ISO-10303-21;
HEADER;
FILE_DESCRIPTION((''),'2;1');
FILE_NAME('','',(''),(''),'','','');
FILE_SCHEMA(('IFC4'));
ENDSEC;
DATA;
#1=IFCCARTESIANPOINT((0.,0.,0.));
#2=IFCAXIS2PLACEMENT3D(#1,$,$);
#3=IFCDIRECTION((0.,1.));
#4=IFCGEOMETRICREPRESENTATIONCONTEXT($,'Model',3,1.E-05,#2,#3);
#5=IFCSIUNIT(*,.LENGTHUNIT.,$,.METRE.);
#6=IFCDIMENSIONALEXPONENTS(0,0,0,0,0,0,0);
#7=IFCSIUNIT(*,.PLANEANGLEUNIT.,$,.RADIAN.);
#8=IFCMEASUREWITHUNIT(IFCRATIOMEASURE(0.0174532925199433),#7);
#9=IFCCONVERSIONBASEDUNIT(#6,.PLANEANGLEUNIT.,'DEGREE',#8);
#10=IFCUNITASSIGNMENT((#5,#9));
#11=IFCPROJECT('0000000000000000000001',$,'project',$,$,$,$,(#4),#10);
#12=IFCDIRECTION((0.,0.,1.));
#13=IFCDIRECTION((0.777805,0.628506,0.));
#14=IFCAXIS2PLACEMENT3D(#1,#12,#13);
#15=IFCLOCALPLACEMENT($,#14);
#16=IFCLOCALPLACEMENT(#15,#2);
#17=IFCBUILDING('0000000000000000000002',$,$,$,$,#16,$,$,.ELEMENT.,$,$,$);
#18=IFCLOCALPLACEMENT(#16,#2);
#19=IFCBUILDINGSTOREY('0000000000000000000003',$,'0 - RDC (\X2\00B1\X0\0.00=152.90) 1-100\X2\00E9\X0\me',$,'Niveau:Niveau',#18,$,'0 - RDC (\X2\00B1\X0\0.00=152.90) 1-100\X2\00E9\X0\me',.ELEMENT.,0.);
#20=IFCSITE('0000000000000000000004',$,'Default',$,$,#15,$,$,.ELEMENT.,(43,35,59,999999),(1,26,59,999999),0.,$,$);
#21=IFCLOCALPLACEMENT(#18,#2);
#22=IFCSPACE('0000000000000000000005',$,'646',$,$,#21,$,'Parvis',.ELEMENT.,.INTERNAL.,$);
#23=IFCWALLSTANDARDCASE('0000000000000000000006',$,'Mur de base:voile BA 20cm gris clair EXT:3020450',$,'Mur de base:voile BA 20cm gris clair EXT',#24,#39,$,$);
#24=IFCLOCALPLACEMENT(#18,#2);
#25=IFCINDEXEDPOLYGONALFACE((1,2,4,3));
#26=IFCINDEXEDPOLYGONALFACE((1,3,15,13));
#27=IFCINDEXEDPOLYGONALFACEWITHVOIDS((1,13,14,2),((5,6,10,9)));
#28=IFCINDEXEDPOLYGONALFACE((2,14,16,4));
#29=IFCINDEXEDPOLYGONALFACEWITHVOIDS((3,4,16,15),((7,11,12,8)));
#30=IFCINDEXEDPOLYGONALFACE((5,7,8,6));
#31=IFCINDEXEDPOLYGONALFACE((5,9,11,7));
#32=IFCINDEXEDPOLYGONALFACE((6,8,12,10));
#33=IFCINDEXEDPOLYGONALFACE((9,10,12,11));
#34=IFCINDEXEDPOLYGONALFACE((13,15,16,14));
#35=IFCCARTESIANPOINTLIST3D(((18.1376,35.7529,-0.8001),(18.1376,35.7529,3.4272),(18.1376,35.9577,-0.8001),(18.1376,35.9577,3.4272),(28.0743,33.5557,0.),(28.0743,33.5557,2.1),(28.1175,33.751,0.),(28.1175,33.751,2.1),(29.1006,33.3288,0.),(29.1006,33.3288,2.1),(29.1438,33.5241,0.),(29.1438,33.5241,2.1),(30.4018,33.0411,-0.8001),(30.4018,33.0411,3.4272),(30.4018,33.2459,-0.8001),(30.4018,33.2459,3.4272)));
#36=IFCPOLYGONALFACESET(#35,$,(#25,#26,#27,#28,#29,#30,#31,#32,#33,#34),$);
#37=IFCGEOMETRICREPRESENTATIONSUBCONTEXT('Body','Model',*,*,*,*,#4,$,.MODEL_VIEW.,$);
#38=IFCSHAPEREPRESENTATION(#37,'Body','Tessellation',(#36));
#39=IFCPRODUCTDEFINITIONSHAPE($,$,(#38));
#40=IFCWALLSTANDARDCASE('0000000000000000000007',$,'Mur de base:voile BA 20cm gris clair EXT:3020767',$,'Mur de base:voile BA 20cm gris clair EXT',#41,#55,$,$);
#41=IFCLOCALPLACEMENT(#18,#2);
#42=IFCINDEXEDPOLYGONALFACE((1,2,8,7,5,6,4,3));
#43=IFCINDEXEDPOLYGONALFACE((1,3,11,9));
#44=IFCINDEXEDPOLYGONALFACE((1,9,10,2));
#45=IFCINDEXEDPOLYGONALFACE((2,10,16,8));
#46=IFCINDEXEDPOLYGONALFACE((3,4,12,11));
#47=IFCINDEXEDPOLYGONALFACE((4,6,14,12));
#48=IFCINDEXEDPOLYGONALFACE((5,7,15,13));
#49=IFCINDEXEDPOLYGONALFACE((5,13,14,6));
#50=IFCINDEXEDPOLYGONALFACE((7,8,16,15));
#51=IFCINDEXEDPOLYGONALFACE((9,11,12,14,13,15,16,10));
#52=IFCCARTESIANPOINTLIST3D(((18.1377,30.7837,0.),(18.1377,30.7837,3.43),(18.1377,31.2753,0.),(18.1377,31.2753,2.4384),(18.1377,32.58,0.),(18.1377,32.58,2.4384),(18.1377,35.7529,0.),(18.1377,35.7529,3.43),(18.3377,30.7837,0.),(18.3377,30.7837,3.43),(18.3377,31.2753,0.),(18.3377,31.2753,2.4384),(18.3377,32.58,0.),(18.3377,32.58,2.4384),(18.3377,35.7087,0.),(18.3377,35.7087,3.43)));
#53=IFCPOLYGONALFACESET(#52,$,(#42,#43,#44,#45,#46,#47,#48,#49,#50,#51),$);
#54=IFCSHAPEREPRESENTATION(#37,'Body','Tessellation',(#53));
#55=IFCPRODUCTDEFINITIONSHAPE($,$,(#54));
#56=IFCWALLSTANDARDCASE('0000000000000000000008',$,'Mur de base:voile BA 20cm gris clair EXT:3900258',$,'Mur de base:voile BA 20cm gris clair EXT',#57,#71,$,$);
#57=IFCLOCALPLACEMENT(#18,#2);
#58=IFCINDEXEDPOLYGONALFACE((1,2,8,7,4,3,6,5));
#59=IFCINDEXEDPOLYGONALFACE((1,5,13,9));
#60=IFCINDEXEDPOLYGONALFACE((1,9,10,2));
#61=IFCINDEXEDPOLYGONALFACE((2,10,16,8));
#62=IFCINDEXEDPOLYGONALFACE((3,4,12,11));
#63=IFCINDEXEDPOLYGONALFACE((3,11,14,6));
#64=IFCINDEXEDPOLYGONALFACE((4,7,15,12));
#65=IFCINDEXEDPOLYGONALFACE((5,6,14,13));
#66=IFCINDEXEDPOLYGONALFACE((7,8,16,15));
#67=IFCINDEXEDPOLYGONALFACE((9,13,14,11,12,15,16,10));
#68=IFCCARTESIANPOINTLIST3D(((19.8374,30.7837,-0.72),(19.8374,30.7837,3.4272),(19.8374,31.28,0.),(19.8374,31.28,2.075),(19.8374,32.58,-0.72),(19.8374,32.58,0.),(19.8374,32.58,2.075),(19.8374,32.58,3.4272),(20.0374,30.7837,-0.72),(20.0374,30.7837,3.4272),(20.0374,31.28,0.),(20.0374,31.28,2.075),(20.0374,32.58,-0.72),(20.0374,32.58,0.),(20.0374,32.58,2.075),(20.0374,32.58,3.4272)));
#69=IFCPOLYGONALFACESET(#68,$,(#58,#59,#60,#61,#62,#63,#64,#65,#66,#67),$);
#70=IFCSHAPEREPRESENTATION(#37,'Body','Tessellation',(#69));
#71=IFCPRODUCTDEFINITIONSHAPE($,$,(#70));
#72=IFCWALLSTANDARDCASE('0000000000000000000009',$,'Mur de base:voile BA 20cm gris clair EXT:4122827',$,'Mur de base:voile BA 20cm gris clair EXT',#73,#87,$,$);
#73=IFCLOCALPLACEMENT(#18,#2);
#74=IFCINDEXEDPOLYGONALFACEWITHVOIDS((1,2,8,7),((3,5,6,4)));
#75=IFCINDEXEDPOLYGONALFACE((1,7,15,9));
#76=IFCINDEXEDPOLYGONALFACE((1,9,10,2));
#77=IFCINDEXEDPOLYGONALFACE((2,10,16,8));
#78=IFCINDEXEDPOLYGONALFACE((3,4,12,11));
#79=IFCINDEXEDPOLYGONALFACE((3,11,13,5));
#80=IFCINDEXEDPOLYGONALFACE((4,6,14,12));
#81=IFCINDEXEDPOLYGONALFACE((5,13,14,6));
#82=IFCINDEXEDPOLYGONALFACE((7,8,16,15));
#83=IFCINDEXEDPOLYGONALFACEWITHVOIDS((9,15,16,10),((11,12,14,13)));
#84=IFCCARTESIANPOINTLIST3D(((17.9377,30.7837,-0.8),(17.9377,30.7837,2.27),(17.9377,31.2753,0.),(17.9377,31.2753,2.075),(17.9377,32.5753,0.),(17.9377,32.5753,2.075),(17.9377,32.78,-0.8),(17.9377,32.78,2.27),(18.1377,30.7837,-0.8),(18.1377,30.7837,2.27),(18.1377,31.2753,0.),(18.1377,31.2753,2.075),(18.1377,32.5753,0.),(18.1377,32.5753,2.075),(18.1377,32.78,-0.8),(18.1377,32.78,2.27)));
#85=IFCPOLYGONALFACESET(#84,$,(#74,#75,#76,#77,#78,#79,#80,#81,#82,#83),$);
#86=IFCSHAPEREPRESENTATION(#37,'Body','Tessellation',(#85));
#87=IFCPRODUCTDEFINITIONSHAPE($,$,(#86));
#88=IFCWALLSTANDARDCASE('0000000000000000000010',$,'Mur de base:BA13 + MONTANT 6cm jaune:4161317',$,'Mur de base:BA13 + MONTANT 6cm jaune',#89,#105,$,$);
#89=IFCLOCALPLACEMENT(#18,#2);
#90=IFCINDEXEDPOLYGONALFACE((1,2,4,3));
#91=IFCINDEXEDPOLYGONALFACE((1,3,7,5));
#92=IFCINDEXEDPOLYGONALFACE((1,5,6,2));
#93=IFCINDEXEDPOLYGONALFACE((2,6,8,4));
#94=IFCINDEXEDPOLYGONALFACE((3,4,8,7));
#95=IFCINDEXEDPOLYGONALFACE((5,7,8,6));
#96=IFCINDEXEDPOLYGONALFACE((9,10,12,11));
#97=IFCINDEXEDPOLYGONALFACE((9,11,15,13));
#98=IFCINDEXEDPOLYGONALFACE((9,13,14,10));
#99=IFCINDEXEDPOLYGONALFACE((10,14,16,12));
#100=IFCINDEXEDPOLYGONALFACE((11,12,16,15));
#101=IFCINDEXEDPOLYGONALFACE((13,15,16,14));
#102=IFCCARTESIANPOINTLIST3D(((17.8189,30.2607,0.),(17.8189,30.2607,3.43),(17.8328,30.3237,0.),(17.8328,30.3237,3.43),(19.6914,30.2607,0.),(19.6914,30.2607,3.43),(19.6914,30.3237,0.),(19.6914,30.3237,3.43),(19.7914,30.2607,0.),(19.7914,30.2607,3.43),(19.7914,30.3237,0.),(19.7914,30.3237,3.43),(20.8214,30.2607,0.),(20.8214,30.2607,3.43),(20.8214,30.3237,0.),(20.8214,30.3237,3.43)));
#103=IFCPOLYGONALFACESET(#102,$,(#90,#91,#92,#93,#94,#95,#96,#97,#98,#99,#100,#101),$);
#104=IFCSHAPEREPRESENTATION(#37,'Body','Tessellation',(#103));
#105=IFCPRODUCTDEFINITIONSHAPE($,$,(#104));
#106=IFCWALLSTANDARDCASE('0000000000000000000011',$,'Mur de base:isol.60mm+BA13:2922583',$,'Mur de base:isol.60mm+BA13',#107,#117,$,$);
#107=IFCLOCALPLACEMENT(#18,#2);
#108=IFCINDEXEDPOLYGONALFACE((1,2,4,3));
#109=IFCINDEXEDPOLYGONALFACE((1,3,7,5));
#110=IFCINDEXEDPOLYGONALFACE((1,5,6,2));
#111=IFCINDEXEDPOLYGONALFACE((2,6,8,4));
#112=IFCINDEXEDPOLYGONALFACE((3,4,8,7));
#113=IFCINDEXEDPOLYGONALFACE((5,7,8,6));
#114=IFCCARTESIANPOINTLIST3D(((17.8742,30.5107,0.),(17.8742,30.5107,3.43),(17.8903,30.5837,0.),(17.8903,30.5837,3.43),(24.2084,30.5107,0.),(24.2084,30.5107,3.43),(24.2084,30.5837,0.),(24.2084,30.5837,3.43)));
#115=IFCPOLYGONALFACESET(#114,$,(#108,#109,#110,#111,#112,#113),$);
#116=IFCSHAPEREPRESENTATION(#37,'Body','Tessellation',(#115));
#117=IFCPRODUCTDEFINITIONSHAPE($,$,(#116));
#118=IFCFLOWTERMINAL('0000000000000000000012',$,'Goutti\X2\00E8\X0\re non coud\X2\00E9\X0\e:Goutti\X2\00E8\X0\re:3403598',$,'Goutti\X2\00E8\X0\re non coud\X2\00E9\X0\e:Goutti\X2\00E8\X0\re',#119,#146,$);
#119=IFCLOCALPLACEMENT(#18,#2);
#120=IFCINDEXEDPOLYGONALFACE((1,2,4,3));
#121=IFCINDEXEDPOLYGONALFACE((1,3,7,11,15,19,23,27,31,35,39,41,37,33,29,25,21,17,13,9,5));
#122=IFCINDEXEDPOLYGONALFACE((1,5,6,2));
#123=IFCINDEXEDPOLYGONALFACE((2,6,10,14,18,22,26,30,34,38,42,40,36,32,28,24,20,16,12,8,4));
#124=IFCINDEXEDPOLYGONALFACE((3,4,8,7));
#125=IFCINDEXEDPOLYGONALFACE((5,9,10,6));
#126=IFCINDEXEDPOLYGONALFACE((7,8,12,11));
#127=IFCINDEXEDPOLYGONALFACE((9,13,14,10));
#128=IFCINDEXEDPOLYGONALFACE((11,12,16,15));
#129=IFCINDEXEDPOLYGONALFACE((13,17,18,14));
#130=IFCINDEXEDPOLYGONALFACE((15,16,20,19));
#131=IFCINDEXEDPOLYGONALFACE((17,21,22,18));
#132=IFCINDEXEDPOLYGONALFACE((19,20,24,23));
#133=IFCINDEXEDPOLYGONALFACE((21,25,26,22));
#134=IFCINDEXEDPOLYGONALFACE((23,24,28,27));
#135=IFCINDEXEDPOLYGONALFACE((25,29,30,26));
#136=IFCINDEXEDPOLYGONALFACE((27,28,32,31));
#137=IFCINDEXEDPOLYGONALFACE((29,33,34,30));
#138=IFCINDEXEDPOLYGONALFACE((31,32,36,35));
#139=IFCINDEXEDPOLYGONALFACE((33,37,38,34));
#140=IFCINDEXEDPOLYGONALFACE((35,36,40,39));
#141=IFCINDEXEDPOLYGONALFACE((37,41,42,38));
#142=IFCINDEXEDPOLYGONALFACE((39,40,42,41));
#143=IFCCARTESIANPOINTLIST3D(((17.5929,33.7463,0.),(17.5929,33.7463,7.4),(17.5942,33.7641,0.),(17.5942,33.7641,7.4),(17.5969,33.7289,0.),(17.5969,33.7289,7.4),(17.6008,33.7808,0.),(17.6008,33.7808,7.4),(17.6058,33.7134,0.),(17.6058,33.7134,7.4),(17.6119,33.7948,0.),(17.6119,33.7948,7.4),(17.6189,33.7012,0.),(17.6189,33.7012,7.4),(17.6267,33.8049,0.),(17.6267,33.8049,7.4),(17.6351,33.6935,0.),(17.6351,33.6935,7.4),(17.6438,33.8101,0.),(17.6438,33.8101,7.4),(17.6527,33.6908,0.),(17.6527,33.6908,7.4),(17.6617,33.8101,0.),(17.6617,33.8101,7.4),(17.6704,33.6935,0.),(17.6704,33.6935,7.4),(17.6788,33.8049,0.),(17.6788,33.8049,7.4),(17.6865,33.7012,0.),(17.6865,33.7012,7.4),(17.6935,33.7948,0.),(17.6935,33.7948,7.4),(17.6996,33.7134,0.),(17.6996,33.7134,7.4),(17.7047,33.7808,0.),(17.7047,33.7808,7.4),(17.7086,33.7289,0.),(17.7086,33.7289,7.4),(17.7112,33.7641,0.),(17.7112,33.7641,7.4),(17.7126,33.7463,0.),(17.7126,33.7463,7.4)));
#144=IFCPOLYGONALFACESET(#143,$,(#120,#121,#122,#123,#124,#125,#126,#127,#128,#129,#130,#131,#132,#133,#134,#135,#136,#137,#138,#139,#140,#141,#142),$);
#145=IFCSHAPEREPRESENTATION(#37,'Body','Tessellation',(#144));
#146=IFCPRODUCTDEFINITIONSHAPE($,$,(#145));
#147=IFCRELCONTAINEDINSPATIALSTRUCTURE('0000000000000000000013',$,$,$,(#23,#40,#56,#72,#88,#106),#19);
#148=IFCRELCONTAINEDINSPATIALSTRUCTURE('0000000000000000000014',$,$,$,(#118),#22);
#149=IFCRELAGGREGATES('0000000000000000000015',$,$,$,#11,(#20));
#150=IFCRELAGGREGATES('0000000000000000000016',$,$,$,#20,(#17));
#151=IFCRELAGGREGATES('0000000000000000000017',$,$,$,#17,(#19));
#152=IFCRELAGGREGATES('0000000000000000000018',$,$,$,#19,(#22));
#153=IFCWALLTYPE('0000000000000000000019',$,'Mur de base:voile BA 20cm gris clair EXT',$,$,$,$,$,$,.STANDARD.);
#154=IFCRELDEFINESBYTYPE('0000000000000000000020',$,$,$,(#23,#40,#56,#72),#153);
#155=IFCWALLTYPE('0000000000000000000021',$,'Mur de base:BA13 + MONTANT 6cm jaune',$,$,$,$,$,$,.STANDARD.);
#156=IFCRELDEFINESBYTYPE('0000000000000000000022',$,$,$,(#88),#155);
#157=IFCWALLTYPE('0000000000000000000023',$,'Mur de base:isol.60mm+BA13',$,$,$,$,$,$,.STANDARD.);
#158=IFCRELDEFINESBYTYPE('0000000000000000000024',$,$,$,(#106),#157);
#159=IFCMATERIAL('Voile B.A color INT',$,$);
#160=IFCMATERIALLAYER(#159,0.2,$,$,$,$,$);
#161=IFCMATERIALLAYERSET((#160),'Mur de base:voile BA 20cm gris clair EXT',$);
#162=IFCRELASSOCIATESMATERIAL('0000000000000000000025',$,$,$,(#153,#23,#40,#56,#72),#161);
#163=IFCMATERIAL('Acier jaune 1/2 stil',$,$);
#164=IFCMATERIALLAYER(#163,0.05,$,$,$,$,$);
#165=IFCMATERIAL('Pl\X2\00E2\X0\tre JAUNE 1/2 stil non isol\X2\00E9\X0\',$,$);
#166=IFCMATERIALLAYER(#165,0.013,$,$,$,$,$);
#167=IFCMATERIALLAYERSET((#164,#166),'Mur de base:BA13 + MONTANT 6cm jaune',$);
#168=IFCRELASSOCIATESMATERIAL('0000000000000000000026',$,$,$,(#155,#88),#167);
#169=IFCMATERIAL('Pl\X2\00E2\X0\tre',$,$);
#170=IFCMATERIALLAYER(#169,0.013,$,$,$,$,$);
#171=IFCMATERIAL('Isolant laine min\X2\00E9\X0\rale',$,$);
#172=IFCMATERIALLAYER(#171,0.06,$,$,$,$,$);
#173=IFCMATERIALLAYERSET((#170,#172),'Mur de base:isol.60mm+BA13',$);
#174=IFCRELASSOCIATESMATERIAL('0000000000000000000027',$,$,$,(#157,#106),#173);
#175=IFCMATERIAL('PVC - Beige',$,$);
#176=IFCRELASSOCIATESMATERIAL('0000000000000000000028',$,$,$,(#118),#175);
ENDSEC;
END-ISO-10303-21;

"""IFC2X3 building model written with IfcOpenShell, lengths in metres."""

from ifc_helpers import new_model, entity, si_unit, converted_unit, direction, frame, frame_2d, origin, origin_2d_with_axis, place, context, subcontext, project, spatial, polyline, rectangle, circle, outline, extrude, source, transform, mapped, material, layer, layer_set, layer_usage, type_object, element, save


model = new_model("IFC2X3")

# Units and contexts
model_context = context("Model", 3, precision=1e-05, world=origin(), true_north=direction((0.0, 1.0)))
body_context = subcontext(model_context, "Body", "Model", "MODEL_VIEW")
ifc_project = project(units=[si_unit("LENGTHUNIT", "METRE"), converted_unit("PLANEANGLEUNIT", "DEGREE", entity("IfcRatioMeasure", 0.0174532925199433), si_unit("PLANEANGLEUNIT", "RADIAN"), dimensions=[0, 0, 0, 0, 0, 0, 0])], contexts=[model_context])

# Site, building, storey
site_placement = place(None, frame((0.0, 0.0, 0.0), z_axis=(0.0, 0.0, 1.0), x_axis=(0.777805, 0.628506, 0.0)))
site = spatial("IfcSite", under=ifc_project, at=site_placement, Name="Default", CompositionType="ELEMENT", RefLatitude=(43, 35, 59, 999999), RefLongitude=(1, 26, 59, 999999), RefElevation=0.0)
building_placement = place(site_placement, origin())
building = spatial("IfcBuilding", under=site, at=building_placement, CompositionType="ELEMENT")
storey_placement = place(building_placement, origin())
storey = spatial("IfcBuildingStorey", under=building, at=storey_placement, Name="0 - RDC (±0.00=152.90) 1-100éme", ObjectType="Niveau:Niveau", LongName="0 - RDC (±0.00=152.90) 1-100éme", CompositionType="ELEMENT", Elevation=0.0)

# Shared definitions
ifc_material_1 = material(Name="Plâtre")

# Shared definitions
ifc_material_2 = material(Name="Voile B.A color INT")
ifc_layer_1 = layer(ifc_material_2, 0.2)
ifc_layer_set_1 = layer_set([ifc_layer_1], Name="Mur de base:voile BA 20cm gris clair EXT")
wall_type_1 = type_object("IfcWallType", Name="Mur de base:voile BA 20cm gris clair EXT", PredefinedType="STANDARD", material=ifc_layer_set_1)

# Walls, openings
ifc_layer_usage_1 = layer_usage(ifc_layer_set_1, "AXIS2", "NEGATIVE", 0.1)
wall_1_placement = place(storey_placement, frame((18.1161, 35.8601, -0.8001), z_axis=(0.0, 0.0, 1.0), x_axis=(0.976415, -0.2159, 0.0)))
wall_1 = element("IfcWallStandardCase", 1, at=wall_1_placement, inside=storey, type_object=wall_type_1, material=ifc_layer_usage_1, Name="Mur de base:voile BA 20cm gris clair EXT:3020450", ObjectType="Mur de base:voile BA 20cm gris clair EXT", context=body_context, shape_type="SweptSolid", body=[
    extrude(outline(polyline([(12.6046, -0.1), (12.5604, 0.1), (0.0, 0.1), (0.0442, -0.1), (12.6046, -0.1)])), origin(), (0.0, 0.0, 1.0), 4.2273),
])
opening_1_placement = place(wall_1_placement, origin())
element("IfcOpeningElement", 2, at=opening_1_placement, cuts=wall_1, ObjectType="Opening", context=body_context, shape_type="SweptSolid", body=[
    extrude(rectangle(XDim=2.1, YDim=1.0511, at=frame_2d((0.0, 0.0), x_axis=(1.0, 0.0))), frame((10.7464, -0.1, 1.8501), z_axis=(0.0, 1.0, 0.0), x_axis=(0.0, 0.0, -1.0)), (0.0, 0.0, 1.0), 0.2),
])
ifc_layer_usage_2 = layer_usage(ifc_layer_set_1, "AXIS2", "NEGATIVE", 0.1)
wall_2_placement = place(storey_placement, frame((18.2377, 30.7837, 0.0), z_axis=(0.0, 0.0, 1.0), x_axis=(0.0, 1.0, 0.0)))
wall_2 = element("IfcWallStandardCase", 3, at=wall_2_placement, inside=storey, type_object=wall_type_1, material=ifc_layer_usage_2, Name="Mur de base:voile BA 20cm gris clair EXT:3020767", ObjectType="Mur de base:voile BA 20cm gris clair EXT", context=body_context, shape_type="SweptSolid", body=[
    extrude(outline(polyline([(0.0, -0.1), (1.7963, -0.1), (1.9963, -0.1), (4.925, -0.1), (4.9692, 0.1), (0.0, 0.1), (0.0, -0.1)])), origin(), (0.0, 0.0, 1.0), 3.43),
])
opening_2_placement = place(wall_2_placement, origin())
element("IfcOpeningElement", 4, at=opening_2_placement, cuts=wall_2, ObjectType="Opening", context=body_context, shape_type="SweptSolid", body=[
    extrude(rectangle(XDim=2.4384, YDim=1.3047, at=origin_2d_with_axis()), frame((1.144, -0.1, 1.2192), z_axis=(0.0, 1.0, 0.0), x_axis=(0.0, 0.0, -1.0)), (0.0, 0.0, 1.0), 0.2),
])
ifc_layer_usage_3 = layer_usage(ifc_layer_set_1, "AXIS2", "NEGATIVE", 0.1)
wall_3_placement = place(storey_placement, frame((19.9374, 32.58, -0.72), z_axis=(0.0, 0.0, 1.0), x_axis=(0.0, -1.0, 0.0)))
wall_3 = element("IfcWallStandardCase", 5, at=wall_3_placement, inside=storey, type_object=wall_type_1, material=ifc_layer_usage_3, Name="Mur de base:voile BA 20cm gris clair EXT:3900258", ObjectType="Mur de base:voile BA 20cm gris clair EXT", context=body_context, shape_type="SweptSolid", body=[
    extrude(rectangle(XDim=1.7963, YDim=0.2, at=frame_2d((0.8982, 0.0), x_axis=(-1.0, 0.0))), origin(), (0.0, 0.0, 1.0), 4.1472),
])
opening_3_placement = place(wall_3_placement, frame((1.3, 0.1, 0.72)))
element("IfcOpeningElement", 6, at=opening_3_placement, cuts=wall_3, ObjectType="Opening", context=body_context, shape_type="SweptSolid", body=[
    extrude(rectangle(XDim=2.075, YDim=1.3, at=frame_2d((1.0375, 0.65), x_axis=(1.0, 0.0))), frame((0.0, 0.0, 0.0), z_axis=(0.0, -1.0, 0.0), x_axis=(0.0, 0.0, 1.0)), (0.0, 0.0, 1.0), 0.2),
])
ifc_layer_usage_4 = layer_usage(ifc_layer_set_1, "AXIS2", "NEGATIVE", 0.1)
wall_4_placement = place(storey_placement, frame((18.0377, 32.78, -0.8), z_axis=(0.0, 0.0, 1.0), x_axis=(0.0, -1.0, 0.0)))
wall_4 = element("IfcWallStandardCase", 7, at=wall_4_placement, inside=storey, type_object=wall_type_1, material=ifc_layer_usage_4, Name="Mur de base:voile BA 20cm gris clair EXT:4122827", ObjectType="Mur de base:voile BA 20cm gris clair EXT", context=body_context, shape_type="SweptSolid", body=[
    extrude(rectangle(XDim=1.9963, YDim=0.2, at=frame_2d((0.9982, 0.0), x_axis=(-1.0, 0.0))), origin(), (0.0, 0.0, 1.0), 3.07),
])
opening_4_placement = place(wall_4_placement, frame((1.5047, 0.1, 0.8)))
element("IfcOpeningElement", 8, at=opening_4_placement, cuts=wall_4, ObjectType="Opening", context=body_context, shape_type="SweptSolid", body=[
    extrude(rectangle(XDim=2.075, YDim=1.3, at=frame_2d((1.0375, 0.65), x_axis=(1.0, 0.0))), frame((0.0, 0.0, 0.0), z_axis=(0.0, -1.0, 0.0), x_axis=(0.0, 0.0, 1.0)), (0.0, 0.0, 1.0), 0.2),
])
ifc_material_3 = material(Name="Acier jaune 1/2 stil")
ifc_layer_2 = layer(ifc_material_3, 0.05)
ifc_material_4 = material(Name="Plâtre JAUNE 1/2 stil non isolé")
ifc_layer_3 = layer(ifc_material_4, 0.013)
ifc_layer_set_2 = layer_set([ifc_layer_2, ifc_layer_3], Name="Mur de base:BA13 + MONTANT 6cm jaune")
ifc_layer_usage_5 = layer_usage(ifc_layer_set_2, "AXIS2", "NEGATIVE", 0.0315)
wall_type_2 = type_object("IfcWallType", Name="Mur de base:BA13 + MONTANT 6cm jaune", PredefinedType="STANDARD", material=ifc_layer_set_2)
wall_5_placement = place(storey_placement, frame((17.8189, 30.2922, 0.0)))
wall_5 = element("IfcWallStandardCase", 9, at=wall_5_placement, inside=storey, type_object=wall_type_2, material=ifc_layer_usage_5, Name="Mur de base:BA13 + MONTANT 6cm jaune:4161317", ObjectType="Mur de base:BA13 + MONTANT 6cm jaune", context=body_context, shape_type="SweptSolid", body=[
    extrude(outline(polyline([(0.0139, 0.0315), (0.0, -0.0315), (3.0025, -0.0315), (3.0025, 0.0315), (0.0139, 0.0315)])), origin(), (0.0, 0.0, 1.0), 3.43),
])
opening_5_placement = place(storey_placement, frame((17.8189, 30.2922, 0.0)))
element("IfcOpeningElement", 10, at=opening_5_placement, cuts=wall_5, ObjectType="Opening", context=body_context, shape_type="SweptSolid", body=[
    extrude(rectangle(XDim=3.43, YDim=0.063, at=frame_2d((0.0, 0.0), x_axis=(1.0, 0.0))), frame((1.8725, 0.0, 1.715), z_axis=(1.0, 0.0, 0.0), x_axis=(0.0, 0.0, -1.0)), (0.0, 0.0, 1.0), 0.1),
])

# Wall
ifc_layer_4 = layer(ifc_material_1, 0.013)
ifc_material_5 = material(Name="Isolant laine minérale")
ifc_layer_5 = layer(ifc_material_5, 0.06)
ifc_layer_set_3 = layer_set([ifc_layer_4, ifc_layer_5], Name="Mur de base:isol.60mm+BA13")
ifc_layer_usage_6 = layer_usage(ifc_layer_set_3, "AXIS2", "NEGATIVE", 0.0365)
wall_type_3 = type_object("IfcWallType", Name="Mur de base:isol.60mm+BA13", PredefinedType="STANDARD", material=ifc_layer_set_3)
wall_6_placement = place(storey_placement, frame((24.2084, 30.5472, 0.0), z_axis=(0.0, 0.0, 1.0), x_axis=(-1.0, 0.0, 0.0)))
element("IfcWallStandardCase", 11, at=wall_6_placement, inside=storey, type_object=wall_type_3, material=ifc_layer_usage_6, Name="Mur de base:isol.60mm+BA13:2922583", ObjectType="Mur de base:isol.60mm+BA13", context=body_context, shape_type="SweptSolid", body=[
    extrude(outline(polyline([(6.3181, -0.0365), (6.3342, 0.0365), (0.0, 0.0365), (0.0, -0.0365), (6.3181, -0.0365)])), origin(), (0.0, 0.0, 1.0), 3.43),
])

# Shared definitions
space_1_placement = place(storey_placement, origin())
space_1 = spatial("IfcSpace", under=storey, at=space_1_placement, Name="646", LongName="Parvis", CompositionType="ELEMENT", InteriorOrExteriorSpace="INTERNAL")

# Flow terminal
ifc_material_6 = material(Name="PVC - Beige")
shared_shape_1 = source(origin(), body_context, "Body", "SweptSolid", [
    extrude(circle(Radius=0.06, at=frame_2d((0.0, 0.0), x_axis=(1.0, 0.0))), frame((0.0, 0.0, 0.0), z_axis=(0.0, 0.0, 1.0), x_axis=(0.0, -1.0, 0.0)), (0.0, 0.0, 1.0), 7.4),
])
flow_terminal_1_placement = place(space_1_placement, frame((17.6527, 33.7508, 0.0)))
element("IfcFlowTerminal", 12, at=flow_terminal_1_placement, inside=space_1, material=ifc_material_6, Name="Gouttière non coudée:Gouttière:3403598", ObjectType="Gouttière non coudée:Gouttière", context=body_context, shape_type="MappedRepresentation", body=[
    mapped(shared_shape_1, transform((0.0, 0.0, 0.0), scale=1.0)),
])

save(model, "model.ifc")
